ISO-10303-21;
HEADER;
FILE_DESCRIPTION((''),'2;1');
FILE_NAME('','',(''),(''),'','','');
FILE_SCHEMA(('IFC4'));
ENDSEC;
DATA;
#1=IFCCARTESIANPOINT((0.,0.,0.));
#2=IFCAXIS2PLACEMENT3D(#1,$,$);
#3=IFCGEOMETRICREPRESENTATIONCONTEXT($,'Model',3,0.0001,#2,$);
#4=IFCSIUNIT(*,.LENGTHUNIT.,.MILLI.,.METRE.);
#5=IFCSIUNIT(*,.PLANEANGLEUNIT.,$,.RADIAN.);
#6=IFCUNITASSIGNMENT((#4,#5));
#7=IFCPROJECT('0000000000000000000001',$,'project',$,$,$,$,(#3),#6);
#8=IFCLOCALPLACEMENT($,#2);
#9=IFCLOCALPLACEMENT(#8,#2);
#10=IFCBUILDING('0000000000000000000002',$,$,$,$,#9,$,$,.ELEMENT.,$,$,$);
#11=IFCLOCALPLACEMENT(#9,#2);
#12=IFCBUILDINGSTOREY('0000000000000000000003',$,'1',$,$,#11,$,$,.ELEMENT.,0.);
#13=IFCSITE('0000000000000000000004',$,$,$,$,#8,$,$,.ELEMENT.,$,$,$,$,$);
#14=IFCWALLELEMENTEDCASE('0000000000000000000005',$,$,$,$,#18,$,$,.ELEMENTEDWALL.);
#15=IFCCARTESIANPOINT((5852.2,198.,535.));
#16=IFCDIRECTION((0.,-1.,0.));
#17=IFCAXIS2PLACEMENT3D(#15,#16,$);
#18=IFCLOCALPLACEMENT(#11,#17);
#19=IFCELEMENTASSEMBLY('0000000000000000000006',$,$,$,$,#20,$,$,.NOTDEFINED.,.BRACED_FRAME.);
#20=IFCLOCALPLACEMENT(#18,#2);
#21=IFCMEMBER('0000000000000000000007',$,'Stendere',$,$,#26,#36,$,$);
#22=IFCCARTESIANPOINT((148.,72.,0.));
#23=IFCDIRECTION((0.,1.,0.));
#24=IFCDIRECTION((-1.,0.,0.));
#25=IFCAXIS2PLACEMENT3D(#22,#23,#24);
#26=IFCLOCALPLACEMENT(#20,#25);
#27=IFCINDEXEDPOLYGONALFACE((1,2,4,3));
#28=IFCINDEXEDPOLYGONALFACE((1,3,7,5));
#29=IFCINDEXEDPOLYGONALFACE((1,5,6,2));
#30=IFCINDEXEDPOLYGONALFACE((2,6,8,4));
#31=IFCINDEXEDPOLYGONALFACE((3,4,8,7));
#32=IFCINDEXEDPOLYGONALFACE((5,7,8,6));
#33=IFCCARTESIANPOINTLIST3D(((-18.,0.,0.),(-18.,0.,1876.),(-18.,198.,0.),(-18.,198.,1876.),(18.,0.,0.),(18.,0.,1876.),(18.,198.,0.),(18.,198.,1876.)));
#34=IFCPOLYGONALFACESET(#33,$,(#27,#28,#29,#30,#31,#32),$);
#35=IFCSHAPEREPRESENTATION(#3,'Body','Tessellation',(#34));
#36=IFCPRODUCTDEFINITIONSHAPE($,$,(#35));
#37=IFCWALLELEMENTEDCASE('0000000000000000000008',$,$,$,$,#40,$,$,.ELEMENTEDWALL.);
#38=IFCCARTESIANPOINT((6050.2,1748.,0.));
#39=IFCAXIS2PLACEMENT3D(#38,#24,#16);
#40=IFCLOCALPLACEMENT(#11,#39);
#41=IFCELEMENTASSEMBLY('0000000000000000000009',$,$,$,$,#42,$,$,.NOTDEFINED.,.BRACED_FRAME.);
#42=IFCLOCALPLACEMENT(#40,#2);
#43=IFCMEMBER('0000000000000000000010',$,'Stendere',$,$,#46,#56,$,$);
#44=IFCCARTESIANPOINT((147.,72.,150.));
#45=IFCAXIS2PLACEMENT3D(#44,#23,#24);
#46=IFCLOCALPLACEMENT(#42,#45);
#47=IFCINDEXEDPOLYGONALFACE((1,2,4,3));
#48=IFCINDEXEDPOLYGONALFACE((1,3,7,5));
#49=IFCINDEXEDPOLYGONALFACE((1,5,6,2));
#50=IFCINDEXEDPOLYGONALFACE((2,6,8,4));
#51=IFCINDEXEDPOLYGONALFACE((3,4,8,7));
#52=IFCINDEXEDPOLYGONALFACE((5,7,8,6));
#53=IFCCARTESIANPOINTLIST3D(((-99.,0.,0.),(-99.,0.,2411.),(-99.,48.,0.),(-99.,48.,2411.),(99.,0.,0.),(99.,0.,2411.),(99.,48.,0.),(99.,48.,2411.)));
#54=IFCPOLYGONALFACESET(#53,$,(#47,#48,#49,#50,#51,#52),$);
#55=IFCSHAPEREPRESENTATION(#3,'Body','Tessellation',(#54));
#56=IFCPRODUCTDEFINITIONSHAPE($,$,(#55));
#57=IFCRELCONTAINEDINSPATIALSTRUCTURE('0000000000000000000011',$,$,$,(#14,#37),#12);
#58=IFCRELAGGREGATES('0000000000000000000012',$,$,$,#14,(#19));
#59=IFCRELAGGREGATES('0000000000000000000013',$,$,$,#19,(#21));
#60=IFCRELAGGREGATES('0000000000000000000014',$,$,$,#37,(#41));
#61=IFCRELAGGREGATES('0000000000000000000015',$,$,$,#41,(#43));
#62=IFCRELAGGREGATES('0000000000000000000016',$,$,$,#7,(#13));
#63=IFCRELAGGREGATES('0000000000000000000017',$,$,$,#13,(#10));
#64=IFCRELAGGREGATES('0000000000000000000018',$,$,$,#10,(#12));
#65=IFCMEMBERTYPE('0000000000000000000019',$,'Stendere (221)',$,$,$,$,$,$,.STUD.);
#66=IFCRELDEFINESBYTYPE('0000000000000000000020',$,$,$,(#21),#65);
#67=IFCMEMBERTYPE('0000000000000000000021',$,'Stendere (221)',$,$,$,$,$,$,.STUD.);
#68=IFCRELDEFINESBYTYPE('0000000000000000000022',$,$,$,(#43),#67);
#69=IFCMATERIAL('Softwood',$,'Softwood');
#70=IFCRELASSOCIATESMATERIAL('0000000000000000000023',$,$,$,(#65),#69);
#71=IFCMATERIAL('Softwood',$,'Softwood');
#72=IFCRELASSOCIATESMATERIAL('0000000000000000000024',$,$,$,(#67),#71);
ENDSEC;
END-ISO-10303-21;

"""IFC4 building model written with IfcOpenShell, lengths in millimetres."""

from ifc_helpers import new_model, si_unit, frame, origin, place, context, project, spatial, rectangle, extrude, material, material_profile, profile_set, type_object, element, aggregate, save


model = new_model("IFC4")

# Units and contexts
model_context = context("Model", 3, precision=0.0001, world=origin())
ifc_project = project(units=[si_unit("LENGTHUNIT", "METRE", prefix="MILLI"), si_unit("PLANEANGLEUNIT", "RADIAN")], contexts=[model_context])

# Site, building, storey
site_placement = place(None, origin())
site = spatial("IfcSite", under=ifc_project, at=site_placement, CompositionType="ELEMENT")
building_placement = place(site_placement, origin())
building = spatial("IfcBuilding", under=site, at=building_placement, CompositionType="ELEMENT")
storey_placement = place(building_placement, origin())
storey = spatial("IfcBuildingStorey", under=building, at=storey_placement, Name="1", CompositionType="ELEMENT", Elevation=0.0)

# Wall, element assembly
wall_1_placement = place(storey_placement, frame((5852.2, 198.0, 535.0), z_axis=(0.0, -1.0, 0.0)))
wall_1 = element("IfcWallElementedCase", 1, at=wall_1_placement, inside=storey, PredefinedType="ELEMENTEDWALL")
assembly_1_placement = place(wall_1_placement, origin())
assembly_1 = element("IfcElementAssembly", 2, at=assembly_1_placement, AssemblyPlace="NOTDEFINED", PredefinedType="BRACED_FRAME")
aggregate(wall_1, [assembly_1])

# Member
ifc_material_1 = material(Name="Softwood", Category="Softwood")
ifc_material_profile_1 = material_profile(ifc_material_1, rectangle(XDim=36.0, YDim=198.0), Name="Stendere (221)")
ifc_profile_set_1 = profile_set([ifc_material_profile_1])
member_type_1 = type_object("IfcMemberType", Name="Stendere (221)", PredefinedType="STUD", material=ifc_profile_set_1)
member_1_placement = place(assembly_1_placement, frame((148.0, 72.0, 0.0), z_axis=(0.0, 1.0, 0.0), x_axis=(-1.0, 0.0, 0.0)))
member_1 = element("IfcMember", 3, at=member_1_placement, type_object=member_type_1, Name="Stendere", context=model_context, shape_type="SweptSolid", body=[
    extrude(rectangle(XDim=36.0, YDim=198.0), frame((0.0, 99.0, 0.0)), (0.0, 0.0, 1.0), 1876.0),
])
aggregate(assembly_1, [member_1])

# Wall, element assembly, member
wall_2_placement = place(storey_placement, frame((6050.2, 1748.0, 0.0), z_axis=(-1.0, 0.0, 0.0), x_axis=(0.0, -1.0, 0.0)))
wall_2 = element("IfcWallElementedCase", 4, at=wall_2_placement, inside=storey, PredefinedType="ELEMENTEDWALL")
assembly_2_placement = place(wall_2_placement, origin())
assembly_2 = element("IfcElementAssembly", 5, at=assembly_2_placement, AssemblyPlace="NOTDEFINED", PredefinedType="BRACED_FRAME")
aggregate(wall_2, [assembly_2])
ifc_material_2 = material(Name="Softwood", Category="Softwood")
ifc_material_profile_2 = material_profile(ifc_material_2, rectangle(XDim=198.0, YDim=48.0), Name="Stendere (221)")
ifc_profile_set_2 = profile_set([ifc_material_profile_2])
member_type_2 = type_object("IfcMemberType", Name="Stendere (221)", PredefinedType="STUD", material=ifc_profile_set_2)
member_2_placement = place(assembly_2_placement, frame((147.0, 72.0, 150.0), z_axis=(0.0, 1.0, 0.0), x_axis=(-1.0, 0.0, 0.0)))
member_2 = element("IfcMember", 6, at=member_2_placement, type_object=member_type_2, Name="Stendere", context=model_context, shape_type="SweptSolid", body=[
    extrude(rectangle(XDim=198.0, YDim=48.0), frame((0.0, 24.0, 0.0)), (0.0, 0.0, 1.0), 2411.0),
])
aggregate(assembly_2, [member_2])

save(model, "model.ifc")
